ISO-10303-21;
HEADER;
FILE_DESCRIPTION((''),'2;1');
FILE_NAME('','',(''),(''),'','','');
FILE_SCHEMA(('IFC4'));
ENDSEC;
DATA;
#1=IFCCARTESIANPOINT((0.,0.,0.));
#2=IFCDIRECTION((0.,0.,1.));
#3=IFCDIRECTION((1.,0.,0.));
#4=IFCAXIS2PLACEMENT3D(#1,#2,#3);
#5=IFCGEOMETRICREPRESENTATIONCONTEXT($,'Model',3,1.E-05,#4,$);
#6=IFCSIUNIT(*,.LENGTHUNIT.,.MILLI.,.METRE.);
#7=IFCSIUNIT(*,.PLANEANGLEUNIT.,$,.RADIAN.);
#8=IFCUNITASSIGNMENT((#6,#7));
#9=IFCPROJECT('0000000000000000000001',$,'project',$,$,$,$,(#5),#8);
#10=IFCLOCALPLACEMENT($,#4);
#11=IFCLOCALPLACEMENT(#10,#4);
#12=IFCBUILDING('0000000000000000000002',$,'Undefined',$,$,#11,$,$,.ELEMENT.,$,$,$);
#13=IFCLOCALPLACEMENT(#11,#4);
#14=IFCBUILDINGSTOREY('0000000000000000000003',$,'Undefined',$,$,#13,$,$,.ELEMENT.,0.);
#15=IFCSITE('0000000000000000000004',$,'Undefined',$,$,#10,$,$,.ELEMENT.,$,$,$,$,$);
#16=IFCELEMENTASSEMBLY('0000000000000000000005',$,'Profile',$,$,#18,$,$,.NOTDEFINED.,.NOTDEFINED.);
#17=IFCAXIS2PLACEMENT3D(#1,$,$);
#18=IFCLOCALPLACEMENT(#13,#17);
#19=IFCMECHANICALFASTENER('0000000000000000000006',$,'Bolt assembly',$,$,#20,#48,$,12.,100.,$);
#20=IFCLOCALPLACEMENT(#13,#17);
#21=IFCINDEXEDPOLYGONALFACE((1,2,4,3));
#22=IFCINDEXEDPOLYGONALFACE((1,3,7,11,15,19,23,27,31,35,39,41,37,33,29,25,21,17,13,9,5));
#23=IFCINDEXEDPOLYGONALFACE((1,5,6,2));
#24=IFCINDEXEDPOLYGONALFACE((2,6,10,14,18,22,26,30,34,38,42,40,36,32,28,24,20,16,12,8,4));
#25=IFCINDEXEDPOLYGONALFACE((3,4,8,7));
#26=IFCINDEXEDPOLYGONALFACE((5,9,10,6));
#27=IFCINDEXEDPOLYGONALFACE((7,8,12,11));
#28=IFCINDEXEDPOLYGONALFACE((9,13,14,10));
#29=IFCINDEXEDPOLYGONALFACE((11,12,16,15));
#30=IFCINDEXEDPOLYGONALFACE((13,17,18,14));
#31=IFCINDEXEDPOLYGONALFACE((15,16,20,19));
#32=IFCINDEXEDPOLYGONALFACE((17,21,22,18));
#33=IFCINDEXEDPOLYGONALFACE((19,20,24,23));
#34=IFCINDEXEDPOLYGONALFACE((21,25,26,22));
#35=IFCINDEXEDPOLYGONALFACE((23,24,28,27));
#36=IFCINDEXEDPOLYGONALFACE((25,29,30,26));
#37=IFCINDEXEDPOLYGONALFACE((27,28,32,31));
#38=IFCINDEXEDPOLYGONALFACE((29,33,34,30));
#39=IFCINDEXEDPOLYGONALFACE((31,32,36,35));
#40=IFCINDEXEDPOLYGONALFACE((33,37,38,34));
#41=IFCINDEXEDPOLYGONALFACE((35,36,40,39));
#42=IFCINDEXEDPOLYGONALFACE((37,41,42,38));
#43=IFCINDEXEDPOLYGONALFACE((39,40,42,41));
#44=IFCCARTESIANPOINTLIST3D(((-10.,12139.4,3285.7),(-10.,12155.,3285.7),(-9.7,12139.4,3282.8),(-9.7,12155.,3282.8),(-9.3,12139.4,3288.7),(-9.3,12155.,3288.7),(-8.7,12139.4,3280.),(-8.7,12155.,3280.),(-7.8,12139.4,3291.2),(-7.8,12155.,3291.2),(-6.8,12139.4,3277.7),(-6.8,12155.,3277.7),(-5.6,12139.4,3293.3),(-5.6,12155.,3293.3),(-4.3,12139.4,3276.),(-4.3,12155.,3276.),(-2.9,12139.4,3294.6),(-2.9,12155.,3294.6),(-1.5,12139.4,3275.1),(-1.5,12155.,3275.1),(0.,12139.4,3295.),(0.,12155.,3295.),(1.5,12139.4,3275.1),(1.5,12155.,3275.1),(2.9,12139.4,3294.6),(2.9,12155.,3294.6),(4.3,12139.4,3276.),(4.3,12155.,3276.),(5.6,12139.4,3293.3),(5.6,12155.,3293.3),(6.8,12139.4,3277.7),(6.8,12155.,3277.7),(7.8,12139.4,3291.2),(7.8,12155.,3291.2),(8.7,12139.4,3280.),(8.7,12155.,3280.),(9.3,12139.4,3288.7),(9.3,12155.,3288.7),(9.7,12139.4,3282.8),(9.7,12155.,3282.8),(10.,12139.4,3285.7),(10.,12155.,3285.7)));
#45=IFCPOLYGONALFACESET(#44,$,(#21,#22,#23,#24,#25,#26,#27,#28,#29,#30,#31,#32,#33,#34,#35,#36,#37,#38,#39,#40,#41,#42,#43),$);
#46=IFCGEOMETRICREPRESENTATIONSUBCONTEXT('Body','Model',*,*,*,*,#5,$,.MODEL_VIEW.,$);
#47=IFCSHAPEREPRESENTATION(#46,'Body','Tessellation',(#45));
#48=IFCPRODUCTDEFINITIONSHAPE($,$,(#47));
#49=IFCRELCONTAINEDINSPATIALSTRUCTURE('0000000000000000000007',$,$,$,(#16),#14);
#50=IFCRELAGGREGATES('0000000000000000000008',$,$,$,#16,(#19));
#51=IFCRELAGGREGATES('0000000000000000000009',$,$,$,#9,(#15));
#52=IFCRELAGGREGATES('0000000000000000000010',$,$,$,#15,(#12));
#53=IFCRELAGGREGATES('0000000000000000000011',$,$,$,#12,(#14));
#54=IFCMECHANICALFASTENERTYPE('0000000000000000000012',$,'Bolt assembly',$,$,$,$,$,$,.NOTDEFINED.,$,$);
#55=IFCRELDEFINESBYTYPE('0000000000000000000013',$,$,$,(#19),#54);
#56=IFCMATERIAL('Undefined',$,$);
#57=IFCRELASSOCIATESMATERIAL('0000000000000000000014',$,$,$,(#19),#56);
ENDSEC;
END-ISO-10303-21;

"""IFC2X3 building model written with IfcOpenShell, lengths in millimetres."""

from ifc_helpers import new_model, si_unit, frame, origin_with_axes, origin_2d_with_axis, place, context, subcontext, project, spatial, circle, extrude, source, transform, mapped, material, type_object, element, aggregate, save


model = new_model("IFC2X3")

# Units and contexts
model_context = context("Model", 3, precision=1e-05, world=origin_with_axes())
body_context = subcontext(model_context, "Body", "Model", "MODEL_VIEW")
ifc_project = project(units=[si_unit("LENGTHUNIT", "METRE", prefix="MILLI"), si_unit("PLANEANGLEUNIT", "RADIAN")], contexts=[model_context])

# Site, building, storey
site_placement = place(None, origin_with_axes())
site = spatial("IfcSite", under=ifc_project, at=site_placement, Name="Undefined", CompositionType="ELEMENT")
building_placement = place(site_placement, origin_with_axes())
building = spatial("IfcBuilding", under=site, at=building_placement, Name="Undefined", CompositionType="ELEMENT")
storey_placement = place(building_placement, origin_with_axes())
storey = spatial("IfcBuildingStorey", under=building, at=storey_placement, Name="Undefined", CompositionType="ELEMENT", Elevation=0.0)

# Element assembly
assembly_1_placement = place(storey_placement, origin_with_axes())
assembly_1 = element("IfcElementAssembly", 1, at=assembly_1_placement, inside=storey, Name="Profile", AssemblyPlace="NOTDEFINED", PredefinedType="NOTDEFINED")

# Mechanical fastener
mechanical_fastener_type = type_object("IfcMechanicalFastenerType", Name="Bolt assembly")
ifc_material_1 = material(Name="Undefined")
shared_shape_1 = source(origin_with_axes(), body_context, "Body", "SweptSolid", [
    extrude(circle(Radius=10.0, at=origin_2d_with_axis()), frame((0.0, 0.0, 0.0), z_axis=(0.0, 1.0, 0.0), x_axis=(1.0, 0.0, 0.0)), (0.0, 0.0, 1.0), 15.6),
])
mechanical_fastener_1_placement = place(assembly_1_placement, frame((0.0, 12155.0, 3285.0), z_axis=(1.0, 0.0, 0.0), x_axis=(0.0, 0.0, 1.0)))
mechanical_fastener_1 = element("IfcMechanicalFastener", 2, at=mechanical_fastener_1_placement, type_object=mechanical_fastener_type, material=ifc_material_1, Name="Bolt assembly", NominalDiameter=12.0, NominalLength=100.0, context=body_context, shape_type="MappedRepresentation", body=[
    mapped(shared_shape_1, transform((0.0, 0.0, 0.0))),
])
aggregate(assembly_1, [mechanical_fastener_1])

save(model, "model.ifc")
